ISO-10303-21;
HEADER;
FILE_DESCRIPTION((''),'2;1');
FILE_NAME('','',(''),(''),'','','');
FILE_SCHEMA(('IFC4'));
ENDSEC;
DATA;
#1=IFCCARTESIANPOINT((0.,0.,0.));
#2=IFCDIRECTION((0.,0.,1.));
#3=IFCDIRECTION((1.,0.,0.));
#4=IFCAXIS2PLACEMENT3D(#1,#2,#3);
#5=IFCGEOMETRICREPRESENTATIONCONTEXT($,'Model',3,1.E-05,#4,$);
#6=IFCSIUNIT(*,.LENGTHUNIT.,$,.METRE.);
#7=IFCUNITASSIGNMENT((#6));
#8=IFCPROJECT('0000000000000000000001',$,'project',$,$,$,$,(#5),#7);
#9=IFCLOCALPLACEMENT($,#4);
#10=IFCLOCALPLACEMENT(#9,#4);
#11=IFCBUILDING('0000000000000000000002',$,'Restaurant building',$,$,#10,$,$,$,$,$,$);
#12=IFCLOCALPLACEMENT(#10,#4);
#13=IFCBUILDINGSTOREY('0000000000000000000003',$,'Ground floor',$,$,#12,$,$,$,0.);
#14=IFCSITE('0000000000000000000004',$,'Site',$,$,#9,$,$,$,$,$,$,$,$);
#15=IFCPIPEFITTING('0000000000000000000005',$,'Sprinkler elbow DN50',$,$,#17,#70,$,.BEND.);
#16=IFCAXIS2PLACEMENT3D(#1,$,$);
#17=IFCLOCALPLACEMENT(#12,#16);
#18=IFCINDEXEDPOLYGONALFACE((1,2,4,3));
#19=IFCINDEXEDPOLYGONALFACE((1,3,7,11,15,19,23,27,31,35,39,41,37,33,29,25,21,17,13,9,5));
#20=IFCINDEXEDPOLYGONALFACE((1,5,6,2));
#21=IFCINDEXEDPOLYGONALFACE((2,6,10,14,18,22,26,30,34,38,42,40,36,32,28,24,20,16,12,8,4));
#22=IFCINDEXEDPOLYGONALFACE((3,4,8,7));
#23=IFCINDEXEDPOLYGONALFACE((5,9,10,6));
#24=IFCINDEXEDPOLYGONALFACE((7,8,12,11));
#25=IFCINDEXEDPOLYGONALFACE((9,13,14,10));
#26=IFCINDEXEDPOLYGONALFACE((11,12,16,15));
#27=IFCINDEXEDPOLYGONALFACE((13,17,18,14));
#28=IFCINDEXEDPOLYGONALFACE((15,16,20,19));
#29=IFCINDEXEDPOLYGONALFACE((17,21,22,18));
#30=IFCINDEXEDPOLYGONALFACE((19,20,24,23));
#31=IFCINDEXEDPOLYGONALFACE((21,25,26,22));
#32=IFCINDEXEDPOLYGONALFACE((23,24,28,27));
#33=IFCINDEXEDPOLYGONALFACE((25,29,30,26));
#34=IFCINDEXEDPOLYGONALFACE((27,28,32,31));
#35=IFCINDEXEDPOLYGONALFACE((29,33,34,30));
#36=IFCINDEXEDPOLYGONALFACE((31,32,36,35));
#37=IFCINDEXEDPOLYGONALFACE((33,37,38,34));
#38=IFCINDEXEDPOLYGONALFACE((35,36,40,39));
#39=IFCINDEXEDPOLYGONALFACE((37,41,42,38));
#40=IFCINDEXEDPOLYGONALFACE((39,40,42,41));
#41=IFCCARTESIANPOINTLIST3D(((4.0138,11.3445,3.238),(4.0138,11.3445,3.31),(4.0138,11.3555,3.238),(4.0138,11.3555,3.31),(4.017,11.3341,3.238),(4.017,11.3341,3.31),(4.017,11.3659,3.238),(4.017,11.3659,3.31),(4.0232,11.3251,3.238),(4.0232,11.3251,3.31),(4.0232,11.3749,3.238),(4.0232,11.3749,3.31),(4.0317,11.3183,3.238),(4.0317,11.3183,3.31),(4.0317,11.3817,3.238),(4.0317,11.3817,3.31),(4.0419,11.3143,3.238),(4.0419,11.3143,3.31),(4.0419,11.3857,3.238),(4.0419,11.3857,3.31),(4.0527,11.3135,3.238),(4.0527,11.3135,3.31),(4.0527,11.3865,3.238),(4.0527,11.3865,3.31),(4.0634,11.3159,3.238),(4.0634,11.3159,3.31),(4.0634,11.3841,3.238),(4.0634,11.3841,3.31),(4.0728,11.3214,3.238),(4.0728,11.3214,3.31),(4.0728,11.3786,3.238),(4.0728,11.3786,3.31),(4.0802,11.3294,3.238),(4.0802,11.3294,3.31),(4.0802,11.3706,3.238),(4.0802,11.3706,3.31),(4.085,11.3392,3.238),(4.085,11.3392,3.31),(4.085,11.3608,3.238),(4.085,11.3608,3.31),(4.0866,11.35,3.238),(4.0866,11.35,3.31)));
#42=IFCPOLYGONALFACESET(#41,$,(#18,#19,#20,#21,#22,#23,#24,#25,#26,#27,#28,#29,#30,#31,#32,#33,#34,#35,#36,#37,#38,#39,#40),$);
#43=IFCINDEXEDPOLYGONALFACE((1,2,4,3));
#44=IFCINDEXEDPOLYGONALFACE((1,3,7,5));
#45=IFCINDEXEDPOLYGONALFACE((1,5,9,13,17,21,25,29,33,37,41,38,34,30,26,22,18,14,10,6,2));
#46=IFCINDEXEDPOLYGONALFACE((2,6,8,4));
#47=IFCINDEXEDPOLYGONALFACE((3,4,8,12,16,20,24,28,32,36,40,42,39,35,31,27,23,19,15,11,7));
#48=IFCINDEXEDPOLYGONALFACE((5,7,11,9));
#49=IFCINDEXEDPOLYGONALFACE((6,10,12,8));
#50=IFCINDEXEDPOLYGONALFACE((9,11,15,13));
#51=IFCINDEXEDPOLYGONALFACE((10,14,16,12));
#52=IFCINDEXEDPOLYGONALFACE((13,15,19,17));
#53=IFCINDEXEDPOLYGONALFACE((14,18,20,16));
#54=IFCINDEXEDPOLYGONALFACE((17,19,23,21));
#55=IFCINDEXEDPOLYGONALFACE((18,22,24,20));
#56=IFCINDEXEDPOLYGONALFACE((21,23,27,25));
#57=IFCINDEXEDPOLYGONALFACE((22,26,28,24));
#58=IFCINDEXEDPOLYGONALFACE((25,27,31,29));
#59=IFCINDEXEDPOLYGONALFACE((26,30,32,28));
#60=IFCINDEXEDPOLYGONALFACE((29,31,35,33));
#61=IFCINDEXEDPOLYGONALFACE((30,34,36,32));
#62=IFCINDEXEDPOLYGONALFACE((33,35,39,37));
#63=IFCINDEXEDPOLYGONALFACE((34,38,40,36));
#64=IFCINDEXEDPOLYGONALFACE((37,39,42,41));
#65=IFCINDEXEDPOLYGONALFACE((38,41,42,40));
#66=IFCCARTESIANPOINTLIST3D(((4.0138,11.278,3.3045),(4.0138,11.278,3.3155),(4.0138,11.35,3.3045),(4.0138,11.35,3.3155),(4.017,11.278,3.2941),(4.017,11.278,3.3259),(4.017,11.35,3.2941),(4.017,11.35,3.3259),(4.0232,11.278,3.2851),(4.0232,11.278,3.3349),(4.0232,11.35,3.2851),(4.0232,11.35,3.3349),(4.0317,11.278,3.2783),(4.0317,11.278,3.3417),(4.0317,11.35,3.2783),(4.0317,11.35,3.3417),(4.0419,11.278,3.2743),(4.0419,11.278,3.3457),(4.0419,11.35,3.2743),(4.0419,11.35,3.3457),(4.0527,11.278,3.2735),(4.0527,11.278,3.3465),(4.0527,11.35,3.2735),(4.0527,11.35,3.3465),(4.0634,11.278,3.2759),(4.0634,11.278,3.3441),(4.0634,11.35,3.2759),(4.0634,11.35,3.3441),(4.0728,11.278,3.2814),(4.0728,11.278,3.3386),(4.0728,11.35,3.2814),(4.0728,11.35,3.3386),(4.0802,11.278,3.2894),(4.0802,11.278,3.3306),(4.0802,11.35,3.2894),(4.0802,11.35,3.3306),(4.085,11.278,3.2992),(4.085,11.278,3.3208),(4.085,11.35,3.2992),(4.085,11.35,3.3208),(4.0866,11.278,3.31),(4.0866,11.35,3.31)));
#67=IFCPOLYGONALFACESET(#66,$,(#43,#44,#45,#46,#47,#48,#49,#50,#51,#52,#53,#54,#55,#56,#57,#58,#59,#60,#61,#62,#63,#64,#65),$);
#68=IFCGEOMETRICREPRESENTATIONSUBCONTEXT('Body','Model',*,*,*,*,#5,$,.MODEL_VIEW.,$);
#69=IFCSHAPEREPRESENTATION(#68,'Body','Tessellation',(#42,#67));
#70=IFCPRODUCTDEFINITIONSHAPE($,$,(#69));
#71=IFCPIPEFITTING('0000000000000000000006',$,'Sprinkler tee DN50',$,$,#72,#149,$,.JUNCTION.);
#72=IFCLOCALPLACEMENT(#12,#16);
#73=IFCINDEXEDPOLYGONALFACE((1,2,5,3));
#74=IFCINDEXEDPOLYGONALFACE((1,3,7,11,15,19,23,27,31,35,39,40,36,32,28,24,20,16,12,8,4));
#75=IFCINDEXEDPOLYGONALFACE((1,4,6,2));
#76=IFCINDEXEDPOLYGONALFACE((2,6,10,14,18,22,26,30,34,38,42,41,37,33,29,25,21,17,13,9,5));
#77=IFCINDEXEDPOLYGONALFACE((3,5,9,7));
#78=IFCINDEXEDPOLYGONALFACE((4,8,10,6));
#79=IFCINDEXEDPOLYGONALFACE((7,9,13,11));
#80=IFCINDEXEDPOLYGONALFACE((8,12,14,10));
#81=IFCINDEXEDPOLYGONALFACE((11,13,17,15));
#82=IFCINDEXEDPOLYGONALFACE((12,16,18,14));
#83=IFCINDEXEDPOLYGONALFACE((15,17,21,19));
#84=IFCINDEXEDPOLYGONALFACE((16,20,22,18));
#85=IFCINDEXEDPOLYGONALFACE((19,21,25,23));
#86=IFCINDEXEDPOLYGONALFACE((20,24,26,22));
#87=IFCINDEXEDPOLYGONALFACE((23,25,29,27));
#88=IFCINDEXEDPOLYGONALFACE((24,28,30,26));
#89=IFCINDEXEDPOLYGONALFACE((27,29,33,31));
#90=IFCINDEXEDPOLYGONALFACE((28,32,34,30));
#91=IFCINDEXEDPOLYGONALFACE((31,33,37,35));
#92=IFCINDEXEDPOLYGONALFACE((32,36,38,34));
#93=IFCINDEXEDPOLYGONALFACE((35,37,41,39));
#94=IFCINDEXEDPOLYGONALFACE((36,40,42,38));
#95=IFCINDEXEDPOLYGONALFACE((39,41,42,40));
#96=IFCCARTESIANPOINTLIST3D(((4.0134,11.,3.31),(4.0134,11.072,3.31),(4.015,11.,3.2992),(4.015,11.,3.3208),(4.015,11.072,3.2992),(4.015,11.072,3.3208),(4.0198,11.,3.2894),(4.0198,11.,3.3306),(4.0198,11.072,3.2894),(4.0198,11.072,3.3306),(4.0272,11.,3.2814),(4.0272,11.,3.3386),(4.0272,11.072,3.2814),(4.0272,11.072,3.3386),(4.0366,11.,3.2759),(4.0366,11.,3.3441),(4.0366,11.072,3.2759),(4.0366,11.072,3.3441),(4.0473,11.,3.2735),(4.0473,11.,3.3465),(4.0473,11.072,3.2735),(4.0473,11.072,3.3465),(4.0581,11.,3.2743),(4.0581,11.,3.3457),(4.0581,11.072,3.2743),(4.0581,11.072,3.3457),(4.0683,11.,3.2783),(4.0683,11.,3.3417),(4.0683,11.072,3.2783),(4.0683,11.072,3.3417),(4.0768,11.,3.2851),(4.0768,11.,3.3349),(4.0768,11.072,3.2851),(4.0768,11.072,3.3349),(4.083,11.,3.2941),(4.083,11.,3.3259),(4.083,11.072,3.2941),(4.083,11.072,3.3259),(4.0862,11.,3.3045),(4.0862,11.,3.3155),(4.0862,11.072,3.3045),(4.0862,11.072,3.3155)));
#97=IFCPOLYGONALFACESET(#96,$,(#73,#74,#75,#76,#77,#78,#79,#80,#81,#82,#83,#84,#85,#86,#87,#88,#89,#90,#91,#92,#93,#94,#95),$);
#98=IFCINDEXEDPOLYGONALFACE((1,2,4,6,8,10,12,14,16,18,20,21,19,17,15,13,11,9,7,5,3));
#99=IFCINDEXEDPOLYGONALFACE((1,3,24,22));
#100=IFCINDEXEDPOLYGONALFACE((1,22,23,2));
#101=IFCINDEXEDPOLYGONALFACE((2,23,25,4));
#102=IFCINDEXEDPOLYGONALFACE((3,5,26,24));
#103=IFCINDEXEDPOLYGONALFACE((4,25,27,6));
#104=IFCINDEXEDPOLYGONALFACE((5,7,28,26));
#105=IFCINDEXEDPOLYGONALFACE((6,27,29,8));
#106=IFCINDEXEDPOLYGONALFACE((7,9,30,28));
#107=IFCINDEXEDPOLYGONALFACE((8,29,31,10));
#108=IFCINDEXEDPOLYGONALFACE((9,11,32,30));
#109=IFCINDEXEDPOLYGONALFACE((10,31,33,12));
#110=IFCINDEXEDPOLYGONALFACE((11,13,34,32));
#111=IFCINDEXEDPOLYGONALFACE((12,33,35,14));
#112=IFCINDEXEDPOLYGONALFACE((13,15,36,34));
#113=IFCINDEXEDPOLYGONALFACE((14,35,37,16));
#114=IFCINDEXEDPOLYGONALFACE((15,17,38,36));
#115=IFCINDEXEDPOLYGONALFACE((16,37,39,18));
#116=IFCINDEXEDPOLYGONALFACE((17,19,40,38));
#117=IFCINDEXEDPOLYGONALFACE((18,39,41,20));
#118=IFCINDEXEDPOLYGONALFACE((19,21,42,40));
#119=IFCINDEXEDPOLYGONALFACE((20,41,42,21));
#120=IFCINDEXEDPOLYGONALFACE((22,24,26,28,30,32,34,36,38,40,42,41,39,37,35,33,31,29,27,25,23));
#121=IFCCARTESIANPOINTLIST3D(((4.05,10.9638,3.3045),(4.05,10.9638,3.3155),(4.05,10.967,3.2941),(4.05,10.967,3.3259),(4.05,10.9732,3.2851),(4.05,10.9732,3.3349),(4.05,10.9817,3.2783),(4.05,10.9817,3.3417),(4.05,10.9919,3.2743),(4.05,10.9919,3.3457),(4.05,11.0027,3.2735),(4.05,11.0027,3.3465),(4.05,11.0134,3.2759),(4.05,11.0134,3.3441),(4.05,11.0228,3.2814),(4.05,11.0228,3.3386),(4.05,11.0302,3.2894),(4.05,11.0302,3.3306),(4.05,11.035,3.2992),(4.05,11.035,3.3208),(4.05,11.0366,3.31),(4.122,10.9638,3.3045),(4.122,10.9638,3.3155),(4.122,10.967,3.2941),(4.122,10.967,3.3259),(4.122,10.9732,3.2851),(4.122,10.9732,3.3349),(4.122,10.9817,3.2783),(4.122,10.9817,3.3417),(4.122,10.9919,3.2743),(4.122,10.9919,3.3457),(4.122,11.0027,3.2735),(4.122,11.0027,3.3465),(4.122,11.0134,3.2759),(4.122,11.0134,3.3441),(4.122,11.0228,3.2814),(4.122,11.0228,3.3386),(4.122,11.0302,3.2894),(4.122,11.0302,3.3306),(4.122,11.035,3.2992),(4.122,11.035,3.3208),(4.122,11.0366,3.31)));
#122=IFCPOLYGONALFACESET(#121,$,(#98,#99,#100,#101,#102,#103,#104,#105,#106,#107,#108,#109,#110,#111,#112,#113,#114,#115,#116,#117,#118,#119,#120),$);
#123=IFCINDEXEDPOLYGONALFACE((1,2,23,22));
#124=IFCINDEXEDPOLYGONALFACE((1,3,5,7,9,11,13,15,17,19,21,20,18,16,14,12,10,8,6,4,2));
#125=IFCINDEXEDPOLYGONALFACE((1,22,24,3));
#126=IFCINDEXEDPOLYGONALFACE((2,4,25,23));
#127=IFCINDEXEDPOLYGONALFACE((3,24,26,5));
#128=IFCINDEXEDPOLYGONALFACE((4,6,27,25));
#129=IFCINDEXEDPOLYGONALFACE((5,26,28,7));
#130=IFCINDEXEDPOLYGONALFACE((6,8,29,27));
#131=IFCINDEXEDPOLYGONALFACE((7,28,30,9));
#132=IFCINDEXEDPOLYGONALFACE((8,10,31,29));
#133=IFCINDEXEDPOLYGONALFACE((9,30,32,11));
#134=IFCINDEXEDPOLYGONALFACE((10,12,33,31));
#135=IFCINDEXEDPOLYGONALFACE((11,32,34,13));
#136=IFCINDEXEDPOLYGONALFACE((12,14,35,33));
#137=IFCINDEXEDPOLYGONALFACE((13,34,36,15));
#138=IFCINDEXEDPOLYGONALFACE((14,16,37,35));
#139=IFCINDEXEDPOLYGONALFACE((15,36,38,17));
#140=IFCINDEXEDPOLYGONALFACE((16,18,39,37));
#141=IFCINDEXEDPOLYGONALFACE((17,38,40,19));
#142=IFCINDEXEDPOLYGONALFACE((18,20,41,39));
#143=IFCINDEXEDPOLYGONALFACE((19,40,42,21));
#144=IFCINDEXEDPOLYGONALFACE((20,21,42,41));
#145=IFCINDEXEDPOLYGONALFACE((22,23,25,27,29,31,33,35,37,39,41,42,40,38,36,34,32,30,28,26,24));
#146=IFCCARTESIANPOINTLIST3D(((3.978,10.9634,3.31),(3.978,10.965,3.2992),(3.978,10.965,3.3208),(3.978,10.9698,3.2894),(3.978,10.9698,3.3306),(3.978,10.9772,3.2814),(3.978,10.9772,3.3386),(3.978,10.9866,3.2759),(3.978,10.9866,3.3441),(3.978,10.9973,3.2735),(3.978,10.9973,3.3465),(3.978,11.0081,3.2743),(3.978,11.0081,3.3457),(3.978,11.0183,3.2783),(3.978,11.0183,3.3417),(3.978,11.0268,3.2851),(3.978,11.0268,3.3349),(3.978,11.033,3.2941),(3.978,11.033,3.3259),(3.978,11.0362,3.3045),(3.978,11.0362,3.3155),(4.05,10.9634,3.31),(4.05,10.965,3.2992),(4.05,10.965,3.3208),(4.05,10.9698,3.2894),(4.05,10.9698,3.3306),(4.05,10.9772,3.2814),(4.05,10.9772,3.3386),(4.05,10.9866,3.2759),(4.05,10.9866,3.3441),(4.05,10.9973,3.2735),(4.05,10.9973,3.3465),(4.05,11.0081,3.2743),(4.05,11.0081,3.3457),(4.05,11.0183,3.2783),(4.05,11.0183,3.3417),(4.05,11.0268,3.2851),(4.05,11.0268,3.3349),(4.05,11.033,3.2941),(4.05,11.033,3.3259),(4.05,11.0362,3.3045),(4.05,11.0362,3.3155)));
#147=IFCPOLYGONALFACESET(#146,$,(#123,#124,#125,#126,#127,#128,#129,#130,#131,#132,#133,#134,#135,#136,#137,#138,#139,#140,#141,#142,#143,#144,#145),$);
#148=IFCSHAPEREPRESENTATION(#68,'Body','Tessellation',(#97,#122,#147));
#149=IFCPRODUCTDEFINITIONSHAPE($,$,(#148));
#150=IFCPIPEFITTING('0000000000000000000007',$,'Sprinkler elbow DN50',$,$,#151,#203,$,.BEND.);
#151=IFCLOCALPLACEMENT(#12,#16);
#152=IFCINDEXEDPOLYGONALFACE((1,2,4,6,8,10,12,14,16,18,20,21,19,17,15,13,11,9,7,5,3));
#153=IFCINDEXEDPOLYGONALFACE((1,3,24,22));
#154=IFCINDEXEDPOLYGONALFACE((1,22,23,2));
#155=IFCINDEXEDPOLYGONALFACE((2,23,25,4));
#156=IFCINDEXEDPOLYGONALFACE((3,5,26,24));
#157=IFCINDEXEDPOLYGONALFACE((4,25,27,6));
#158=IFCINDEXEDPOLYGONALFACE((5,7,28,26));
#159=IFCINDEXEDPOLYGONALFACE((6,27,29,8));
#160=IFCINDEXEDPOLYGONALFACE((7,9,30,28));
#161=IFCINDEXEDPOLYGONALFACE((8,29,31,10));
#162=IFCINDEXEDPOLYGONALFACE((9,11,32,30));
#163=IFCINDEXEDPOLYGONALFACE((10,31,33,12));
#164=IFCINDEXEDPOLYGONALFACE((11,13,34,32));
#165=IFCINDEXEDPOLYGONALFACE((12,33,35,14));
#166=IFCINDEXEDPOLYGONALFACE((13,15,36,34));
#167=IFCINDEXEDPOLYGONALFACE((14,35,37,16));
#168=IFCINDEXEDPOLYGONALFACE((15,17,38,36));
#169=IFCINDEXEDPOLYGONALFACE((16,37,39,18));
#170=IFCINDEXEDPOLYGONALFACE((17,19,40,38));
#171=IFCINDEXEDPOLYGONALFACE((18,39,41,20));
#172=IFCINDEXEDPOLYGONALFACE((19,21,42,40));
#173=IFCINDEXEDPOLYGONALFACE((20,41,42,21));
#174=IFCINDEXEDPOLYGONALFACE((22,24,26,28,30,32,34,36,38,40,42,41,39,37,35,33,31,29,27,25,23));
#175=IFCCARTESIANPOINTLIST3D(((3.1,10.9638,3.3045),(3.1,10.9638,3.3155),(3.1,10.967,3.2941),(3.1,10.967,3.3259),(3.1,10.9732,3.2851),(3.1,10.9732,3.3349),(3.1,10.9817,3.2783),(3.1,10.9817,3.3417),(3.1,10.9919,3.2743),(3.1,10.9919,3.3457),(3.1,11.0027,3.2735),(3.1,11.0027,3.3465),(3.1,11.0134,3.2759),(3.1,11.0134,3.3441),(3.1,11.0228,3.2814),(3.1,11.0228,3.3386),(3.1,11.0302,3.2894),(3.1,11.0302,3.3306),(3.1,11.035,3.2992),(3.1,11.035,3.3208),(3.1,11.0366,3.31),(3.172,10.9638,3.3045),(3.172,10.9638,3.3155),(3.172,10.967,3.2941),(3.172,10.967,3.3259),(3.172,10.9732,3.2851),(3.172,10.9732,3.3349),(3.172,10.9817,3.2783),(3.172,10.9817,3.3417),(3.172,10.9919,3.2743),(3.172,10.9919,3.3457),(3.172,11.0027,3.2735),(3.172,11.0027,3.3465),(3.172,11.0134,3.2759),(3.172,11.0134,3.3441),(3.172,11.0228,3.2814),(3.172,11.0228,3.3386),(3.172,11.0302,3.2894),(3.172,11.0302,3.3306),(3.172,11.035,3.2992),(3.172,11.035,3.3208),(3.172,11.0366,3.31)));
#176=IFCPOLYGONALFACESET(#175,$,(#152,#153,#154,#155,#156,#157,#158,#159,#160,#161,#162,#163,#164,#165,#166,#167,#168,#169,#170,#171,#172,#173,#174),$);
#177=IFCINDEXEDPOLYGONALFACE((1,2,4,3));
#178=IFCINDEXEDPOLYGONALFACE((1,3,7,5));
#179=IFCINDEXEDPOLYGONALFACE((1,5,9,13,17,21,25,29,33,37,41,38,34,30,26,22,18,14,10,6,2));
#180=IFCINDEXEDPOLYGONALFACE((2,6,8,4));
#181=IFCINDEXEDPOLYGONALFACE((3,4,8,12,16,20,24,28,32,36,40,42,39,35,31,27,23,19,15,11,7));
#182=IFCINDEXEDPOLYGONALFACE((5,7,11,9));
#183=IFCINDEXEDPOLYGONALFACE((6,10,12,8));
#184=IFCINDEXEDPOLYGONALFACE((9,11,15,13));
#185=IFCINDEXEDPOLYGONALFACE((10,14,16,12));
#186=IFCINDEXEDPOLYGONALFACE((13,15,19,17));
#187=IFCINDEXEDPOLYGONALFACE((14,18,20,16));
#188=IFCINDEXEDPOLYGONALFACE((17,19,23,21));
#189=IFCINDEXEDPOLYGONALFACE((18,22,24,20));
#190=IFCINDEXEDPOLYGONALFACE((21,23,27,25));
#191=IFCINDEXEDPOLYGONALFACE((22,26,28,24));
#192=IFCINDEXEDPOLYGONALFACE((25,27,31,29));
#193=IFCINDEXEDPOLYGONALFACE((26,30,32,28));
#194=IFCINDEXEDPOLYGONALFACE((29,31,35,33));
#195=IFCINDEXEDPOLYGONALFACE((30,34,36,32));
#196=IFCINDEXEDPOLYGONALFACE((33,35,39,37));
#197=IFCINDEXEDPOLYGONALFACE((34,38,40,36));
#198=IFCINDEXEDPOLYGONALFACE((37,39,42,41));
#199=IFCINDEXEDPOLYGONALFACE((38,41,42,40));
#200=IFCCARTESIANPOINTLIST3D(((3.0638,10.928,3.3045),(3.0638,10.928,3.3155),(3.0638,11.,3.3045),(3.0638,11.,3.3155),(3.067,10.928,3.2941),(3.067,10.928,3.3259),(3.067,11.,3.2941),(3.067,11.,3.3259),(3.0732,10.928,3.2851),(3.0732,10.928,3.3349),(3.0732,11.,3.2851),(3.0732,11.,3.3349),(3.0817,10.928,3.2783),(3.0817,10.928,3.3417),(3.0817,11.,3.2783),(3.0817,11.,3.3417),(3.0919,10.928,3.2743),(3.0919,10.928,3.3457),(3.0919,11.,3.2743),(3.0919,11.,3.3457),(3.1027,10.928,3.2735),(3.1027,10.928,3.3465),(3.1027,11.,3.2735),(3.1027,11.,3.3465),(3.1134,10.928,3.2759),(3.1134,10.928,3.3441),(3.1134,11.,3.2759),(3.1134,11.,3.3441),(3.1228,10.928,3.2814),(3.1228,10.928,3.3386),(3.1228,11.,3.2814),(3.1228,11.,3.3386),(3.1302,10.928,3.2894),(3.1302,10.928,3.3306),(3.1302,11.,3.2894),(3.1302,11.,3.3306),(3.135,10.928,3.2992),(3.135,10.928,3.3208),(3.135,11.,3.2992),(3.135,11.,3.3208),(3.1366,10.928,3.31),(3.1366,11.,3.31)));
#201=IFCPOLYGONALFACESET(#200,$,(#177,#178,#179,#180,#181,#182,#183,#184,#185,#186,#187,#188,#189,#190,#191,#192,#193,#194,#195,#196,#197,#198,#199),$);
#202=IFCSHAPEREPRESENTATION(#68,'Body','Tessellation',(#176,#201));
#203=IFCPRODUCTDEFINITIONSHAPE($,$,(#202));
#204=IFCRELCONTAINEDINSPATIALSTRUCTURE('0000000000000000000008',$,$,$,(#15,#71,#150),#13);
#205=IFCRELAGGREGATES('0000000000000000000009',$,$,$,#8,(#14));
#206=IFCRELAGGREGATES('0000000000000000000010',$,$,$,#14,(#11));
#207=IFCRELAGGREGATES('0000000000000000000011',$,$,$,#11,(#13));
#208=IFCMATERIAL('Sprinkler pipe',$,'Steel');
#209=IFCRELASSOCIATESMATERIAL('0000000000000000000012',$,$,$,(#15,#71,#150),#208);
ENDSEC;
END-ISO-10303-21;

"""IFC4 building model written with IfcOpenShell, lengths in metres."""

from ifc_helpers import new_model, si_unit, frame, origin_with_axes, origin_2d, place, context, subcontext, project, spatial, circle, extrude, material, element, save


model = new_model("IFC4")

# Units and contexts
model_context = context("Model", 3, precision=1e-05, world=origin_with_axes())
body_context = subcontext(model_context, "Body", "Model", "MODEL_VIEW")
ifc_project = project(units=[si_unit("LENGTHUNIT", "METRE")], contexts=[model_context])

# Site, building, storey
site_placement = place(None, origin_with_axes())
site = spatial("IfcSite", under=ifc_project, at=site_placement, Name="Site")
building_placement = place(site_placement, origin_with_axes())
building = spatial("IfcBuilding", under=site, at=building_placement, Name="Restaurant building")
storey_placement = place(building_placement, origin_with_axes())
storey = spatial("IfcBuildingStorey", under=building, at=storey_placement, Name="Ground floor", Elevation=0.0)

# Shared definitions
ifc_material_1 = material(Name="Sprinkler pipe", Category="Steel")

# Pipe fittings
pipe_fitting_1_placement = place(storey_placement, frame((4.05, 11.35, 3.31)))
element("IfcPipeFitting", 1, at=pipe_fitting_1_placement, inside=storey, material=ifc_material_1, Name="Sprinkler elbow DN50", PredefinedType="BEND", context=body_context, shape_type="SweptSolid", body=[
    extrude(circle(Radius=0.0366, at=origin_2d()), frame((0.0, 0.0, 0.0), z_axis=(0.0, 0.0, -1.0), x_axis=(1.0, 0.0, 0.0)), (0.0, 0.0, 1.0), 0.072),
    extrude(circle(Radius=0.0366, at=origin_2d()), frame((0.0, 0.0, 0.0), z_axis=(0.0, -1.0, 0.0), x_axis=(1.0, 0.0, 0.0)), (0.0, 0.0, 1.0), 0.072),
])
pipe_fitting_2_placement = place(storey_placement, frame((4.05, 11.0, 3.31)))
element("IfcPipeFitting", 2, at=pipe_fitting_2_placement, inside=storey, material=ifc_material_1, Name="Sprinkler tee DN50", PredefinedType="JUNCTION", context=body_context, shape_type="SweptSolid", body=[
    extrude(circle(Radius=0.0366, at=origin_2d()), frame((0.0, 0.0, 0.0), z_axis=(0.0, 1.0, 0.0), x_axis=(-1.0, 0.0, 0.0)), (0.0, 0.0, 1.0), 0.072),
    extrude(circle(Radius=0.0366, at=origin_2d()), frame((0.0, 0.0, 0.0), z_axis=(1.0, 0.0, 0.0), x_axis=(0.0, 1.0, 0.0)), (0.0, 0.0, 1.0), 0.072),
    extrude(circle(Radius=0.0366, at=origin_2d()), frame((0.0, 0.0, 0.0), z_axis=(-1.0, 0.0, 0.0), x_axis=(0.0, -1.0, 0.0)), (0.0, 0.0, 1.0), 0.072),
])
pipe_fitting_3_placement = place(storey_placement, frame((3.1, 11.0, 3.31)))
element("IfcPipeFitting", 3, at=pipe_fitting_3_placement, inside=storey, material=ifc_material_1, Name="Sprinkler elbow DN50", PredefinedType="BEND", context=body_context, shape_type="SweptSolid", body=[
    extrude(circle(Radius=0.0366, at=origin_2d()), frame((0.0, 0.0, 0.0), z_axis=(1.0, 0.0, 0.0), x_axis=(0.0, 1.0, 0.0)), (0.0, 0.0, 1.0), 0.072),
    extrude(circle(Radius=0.0366, at=origin_2d()), frame((0.0, 0.0, 0.0), z_axis=(0.0, -1.0, 0.0), x_axis=(1.0, 0.0, 0.0)), (0.0, 0.0, 1.0), 0.072),
])

save(model, "model.ifc")
